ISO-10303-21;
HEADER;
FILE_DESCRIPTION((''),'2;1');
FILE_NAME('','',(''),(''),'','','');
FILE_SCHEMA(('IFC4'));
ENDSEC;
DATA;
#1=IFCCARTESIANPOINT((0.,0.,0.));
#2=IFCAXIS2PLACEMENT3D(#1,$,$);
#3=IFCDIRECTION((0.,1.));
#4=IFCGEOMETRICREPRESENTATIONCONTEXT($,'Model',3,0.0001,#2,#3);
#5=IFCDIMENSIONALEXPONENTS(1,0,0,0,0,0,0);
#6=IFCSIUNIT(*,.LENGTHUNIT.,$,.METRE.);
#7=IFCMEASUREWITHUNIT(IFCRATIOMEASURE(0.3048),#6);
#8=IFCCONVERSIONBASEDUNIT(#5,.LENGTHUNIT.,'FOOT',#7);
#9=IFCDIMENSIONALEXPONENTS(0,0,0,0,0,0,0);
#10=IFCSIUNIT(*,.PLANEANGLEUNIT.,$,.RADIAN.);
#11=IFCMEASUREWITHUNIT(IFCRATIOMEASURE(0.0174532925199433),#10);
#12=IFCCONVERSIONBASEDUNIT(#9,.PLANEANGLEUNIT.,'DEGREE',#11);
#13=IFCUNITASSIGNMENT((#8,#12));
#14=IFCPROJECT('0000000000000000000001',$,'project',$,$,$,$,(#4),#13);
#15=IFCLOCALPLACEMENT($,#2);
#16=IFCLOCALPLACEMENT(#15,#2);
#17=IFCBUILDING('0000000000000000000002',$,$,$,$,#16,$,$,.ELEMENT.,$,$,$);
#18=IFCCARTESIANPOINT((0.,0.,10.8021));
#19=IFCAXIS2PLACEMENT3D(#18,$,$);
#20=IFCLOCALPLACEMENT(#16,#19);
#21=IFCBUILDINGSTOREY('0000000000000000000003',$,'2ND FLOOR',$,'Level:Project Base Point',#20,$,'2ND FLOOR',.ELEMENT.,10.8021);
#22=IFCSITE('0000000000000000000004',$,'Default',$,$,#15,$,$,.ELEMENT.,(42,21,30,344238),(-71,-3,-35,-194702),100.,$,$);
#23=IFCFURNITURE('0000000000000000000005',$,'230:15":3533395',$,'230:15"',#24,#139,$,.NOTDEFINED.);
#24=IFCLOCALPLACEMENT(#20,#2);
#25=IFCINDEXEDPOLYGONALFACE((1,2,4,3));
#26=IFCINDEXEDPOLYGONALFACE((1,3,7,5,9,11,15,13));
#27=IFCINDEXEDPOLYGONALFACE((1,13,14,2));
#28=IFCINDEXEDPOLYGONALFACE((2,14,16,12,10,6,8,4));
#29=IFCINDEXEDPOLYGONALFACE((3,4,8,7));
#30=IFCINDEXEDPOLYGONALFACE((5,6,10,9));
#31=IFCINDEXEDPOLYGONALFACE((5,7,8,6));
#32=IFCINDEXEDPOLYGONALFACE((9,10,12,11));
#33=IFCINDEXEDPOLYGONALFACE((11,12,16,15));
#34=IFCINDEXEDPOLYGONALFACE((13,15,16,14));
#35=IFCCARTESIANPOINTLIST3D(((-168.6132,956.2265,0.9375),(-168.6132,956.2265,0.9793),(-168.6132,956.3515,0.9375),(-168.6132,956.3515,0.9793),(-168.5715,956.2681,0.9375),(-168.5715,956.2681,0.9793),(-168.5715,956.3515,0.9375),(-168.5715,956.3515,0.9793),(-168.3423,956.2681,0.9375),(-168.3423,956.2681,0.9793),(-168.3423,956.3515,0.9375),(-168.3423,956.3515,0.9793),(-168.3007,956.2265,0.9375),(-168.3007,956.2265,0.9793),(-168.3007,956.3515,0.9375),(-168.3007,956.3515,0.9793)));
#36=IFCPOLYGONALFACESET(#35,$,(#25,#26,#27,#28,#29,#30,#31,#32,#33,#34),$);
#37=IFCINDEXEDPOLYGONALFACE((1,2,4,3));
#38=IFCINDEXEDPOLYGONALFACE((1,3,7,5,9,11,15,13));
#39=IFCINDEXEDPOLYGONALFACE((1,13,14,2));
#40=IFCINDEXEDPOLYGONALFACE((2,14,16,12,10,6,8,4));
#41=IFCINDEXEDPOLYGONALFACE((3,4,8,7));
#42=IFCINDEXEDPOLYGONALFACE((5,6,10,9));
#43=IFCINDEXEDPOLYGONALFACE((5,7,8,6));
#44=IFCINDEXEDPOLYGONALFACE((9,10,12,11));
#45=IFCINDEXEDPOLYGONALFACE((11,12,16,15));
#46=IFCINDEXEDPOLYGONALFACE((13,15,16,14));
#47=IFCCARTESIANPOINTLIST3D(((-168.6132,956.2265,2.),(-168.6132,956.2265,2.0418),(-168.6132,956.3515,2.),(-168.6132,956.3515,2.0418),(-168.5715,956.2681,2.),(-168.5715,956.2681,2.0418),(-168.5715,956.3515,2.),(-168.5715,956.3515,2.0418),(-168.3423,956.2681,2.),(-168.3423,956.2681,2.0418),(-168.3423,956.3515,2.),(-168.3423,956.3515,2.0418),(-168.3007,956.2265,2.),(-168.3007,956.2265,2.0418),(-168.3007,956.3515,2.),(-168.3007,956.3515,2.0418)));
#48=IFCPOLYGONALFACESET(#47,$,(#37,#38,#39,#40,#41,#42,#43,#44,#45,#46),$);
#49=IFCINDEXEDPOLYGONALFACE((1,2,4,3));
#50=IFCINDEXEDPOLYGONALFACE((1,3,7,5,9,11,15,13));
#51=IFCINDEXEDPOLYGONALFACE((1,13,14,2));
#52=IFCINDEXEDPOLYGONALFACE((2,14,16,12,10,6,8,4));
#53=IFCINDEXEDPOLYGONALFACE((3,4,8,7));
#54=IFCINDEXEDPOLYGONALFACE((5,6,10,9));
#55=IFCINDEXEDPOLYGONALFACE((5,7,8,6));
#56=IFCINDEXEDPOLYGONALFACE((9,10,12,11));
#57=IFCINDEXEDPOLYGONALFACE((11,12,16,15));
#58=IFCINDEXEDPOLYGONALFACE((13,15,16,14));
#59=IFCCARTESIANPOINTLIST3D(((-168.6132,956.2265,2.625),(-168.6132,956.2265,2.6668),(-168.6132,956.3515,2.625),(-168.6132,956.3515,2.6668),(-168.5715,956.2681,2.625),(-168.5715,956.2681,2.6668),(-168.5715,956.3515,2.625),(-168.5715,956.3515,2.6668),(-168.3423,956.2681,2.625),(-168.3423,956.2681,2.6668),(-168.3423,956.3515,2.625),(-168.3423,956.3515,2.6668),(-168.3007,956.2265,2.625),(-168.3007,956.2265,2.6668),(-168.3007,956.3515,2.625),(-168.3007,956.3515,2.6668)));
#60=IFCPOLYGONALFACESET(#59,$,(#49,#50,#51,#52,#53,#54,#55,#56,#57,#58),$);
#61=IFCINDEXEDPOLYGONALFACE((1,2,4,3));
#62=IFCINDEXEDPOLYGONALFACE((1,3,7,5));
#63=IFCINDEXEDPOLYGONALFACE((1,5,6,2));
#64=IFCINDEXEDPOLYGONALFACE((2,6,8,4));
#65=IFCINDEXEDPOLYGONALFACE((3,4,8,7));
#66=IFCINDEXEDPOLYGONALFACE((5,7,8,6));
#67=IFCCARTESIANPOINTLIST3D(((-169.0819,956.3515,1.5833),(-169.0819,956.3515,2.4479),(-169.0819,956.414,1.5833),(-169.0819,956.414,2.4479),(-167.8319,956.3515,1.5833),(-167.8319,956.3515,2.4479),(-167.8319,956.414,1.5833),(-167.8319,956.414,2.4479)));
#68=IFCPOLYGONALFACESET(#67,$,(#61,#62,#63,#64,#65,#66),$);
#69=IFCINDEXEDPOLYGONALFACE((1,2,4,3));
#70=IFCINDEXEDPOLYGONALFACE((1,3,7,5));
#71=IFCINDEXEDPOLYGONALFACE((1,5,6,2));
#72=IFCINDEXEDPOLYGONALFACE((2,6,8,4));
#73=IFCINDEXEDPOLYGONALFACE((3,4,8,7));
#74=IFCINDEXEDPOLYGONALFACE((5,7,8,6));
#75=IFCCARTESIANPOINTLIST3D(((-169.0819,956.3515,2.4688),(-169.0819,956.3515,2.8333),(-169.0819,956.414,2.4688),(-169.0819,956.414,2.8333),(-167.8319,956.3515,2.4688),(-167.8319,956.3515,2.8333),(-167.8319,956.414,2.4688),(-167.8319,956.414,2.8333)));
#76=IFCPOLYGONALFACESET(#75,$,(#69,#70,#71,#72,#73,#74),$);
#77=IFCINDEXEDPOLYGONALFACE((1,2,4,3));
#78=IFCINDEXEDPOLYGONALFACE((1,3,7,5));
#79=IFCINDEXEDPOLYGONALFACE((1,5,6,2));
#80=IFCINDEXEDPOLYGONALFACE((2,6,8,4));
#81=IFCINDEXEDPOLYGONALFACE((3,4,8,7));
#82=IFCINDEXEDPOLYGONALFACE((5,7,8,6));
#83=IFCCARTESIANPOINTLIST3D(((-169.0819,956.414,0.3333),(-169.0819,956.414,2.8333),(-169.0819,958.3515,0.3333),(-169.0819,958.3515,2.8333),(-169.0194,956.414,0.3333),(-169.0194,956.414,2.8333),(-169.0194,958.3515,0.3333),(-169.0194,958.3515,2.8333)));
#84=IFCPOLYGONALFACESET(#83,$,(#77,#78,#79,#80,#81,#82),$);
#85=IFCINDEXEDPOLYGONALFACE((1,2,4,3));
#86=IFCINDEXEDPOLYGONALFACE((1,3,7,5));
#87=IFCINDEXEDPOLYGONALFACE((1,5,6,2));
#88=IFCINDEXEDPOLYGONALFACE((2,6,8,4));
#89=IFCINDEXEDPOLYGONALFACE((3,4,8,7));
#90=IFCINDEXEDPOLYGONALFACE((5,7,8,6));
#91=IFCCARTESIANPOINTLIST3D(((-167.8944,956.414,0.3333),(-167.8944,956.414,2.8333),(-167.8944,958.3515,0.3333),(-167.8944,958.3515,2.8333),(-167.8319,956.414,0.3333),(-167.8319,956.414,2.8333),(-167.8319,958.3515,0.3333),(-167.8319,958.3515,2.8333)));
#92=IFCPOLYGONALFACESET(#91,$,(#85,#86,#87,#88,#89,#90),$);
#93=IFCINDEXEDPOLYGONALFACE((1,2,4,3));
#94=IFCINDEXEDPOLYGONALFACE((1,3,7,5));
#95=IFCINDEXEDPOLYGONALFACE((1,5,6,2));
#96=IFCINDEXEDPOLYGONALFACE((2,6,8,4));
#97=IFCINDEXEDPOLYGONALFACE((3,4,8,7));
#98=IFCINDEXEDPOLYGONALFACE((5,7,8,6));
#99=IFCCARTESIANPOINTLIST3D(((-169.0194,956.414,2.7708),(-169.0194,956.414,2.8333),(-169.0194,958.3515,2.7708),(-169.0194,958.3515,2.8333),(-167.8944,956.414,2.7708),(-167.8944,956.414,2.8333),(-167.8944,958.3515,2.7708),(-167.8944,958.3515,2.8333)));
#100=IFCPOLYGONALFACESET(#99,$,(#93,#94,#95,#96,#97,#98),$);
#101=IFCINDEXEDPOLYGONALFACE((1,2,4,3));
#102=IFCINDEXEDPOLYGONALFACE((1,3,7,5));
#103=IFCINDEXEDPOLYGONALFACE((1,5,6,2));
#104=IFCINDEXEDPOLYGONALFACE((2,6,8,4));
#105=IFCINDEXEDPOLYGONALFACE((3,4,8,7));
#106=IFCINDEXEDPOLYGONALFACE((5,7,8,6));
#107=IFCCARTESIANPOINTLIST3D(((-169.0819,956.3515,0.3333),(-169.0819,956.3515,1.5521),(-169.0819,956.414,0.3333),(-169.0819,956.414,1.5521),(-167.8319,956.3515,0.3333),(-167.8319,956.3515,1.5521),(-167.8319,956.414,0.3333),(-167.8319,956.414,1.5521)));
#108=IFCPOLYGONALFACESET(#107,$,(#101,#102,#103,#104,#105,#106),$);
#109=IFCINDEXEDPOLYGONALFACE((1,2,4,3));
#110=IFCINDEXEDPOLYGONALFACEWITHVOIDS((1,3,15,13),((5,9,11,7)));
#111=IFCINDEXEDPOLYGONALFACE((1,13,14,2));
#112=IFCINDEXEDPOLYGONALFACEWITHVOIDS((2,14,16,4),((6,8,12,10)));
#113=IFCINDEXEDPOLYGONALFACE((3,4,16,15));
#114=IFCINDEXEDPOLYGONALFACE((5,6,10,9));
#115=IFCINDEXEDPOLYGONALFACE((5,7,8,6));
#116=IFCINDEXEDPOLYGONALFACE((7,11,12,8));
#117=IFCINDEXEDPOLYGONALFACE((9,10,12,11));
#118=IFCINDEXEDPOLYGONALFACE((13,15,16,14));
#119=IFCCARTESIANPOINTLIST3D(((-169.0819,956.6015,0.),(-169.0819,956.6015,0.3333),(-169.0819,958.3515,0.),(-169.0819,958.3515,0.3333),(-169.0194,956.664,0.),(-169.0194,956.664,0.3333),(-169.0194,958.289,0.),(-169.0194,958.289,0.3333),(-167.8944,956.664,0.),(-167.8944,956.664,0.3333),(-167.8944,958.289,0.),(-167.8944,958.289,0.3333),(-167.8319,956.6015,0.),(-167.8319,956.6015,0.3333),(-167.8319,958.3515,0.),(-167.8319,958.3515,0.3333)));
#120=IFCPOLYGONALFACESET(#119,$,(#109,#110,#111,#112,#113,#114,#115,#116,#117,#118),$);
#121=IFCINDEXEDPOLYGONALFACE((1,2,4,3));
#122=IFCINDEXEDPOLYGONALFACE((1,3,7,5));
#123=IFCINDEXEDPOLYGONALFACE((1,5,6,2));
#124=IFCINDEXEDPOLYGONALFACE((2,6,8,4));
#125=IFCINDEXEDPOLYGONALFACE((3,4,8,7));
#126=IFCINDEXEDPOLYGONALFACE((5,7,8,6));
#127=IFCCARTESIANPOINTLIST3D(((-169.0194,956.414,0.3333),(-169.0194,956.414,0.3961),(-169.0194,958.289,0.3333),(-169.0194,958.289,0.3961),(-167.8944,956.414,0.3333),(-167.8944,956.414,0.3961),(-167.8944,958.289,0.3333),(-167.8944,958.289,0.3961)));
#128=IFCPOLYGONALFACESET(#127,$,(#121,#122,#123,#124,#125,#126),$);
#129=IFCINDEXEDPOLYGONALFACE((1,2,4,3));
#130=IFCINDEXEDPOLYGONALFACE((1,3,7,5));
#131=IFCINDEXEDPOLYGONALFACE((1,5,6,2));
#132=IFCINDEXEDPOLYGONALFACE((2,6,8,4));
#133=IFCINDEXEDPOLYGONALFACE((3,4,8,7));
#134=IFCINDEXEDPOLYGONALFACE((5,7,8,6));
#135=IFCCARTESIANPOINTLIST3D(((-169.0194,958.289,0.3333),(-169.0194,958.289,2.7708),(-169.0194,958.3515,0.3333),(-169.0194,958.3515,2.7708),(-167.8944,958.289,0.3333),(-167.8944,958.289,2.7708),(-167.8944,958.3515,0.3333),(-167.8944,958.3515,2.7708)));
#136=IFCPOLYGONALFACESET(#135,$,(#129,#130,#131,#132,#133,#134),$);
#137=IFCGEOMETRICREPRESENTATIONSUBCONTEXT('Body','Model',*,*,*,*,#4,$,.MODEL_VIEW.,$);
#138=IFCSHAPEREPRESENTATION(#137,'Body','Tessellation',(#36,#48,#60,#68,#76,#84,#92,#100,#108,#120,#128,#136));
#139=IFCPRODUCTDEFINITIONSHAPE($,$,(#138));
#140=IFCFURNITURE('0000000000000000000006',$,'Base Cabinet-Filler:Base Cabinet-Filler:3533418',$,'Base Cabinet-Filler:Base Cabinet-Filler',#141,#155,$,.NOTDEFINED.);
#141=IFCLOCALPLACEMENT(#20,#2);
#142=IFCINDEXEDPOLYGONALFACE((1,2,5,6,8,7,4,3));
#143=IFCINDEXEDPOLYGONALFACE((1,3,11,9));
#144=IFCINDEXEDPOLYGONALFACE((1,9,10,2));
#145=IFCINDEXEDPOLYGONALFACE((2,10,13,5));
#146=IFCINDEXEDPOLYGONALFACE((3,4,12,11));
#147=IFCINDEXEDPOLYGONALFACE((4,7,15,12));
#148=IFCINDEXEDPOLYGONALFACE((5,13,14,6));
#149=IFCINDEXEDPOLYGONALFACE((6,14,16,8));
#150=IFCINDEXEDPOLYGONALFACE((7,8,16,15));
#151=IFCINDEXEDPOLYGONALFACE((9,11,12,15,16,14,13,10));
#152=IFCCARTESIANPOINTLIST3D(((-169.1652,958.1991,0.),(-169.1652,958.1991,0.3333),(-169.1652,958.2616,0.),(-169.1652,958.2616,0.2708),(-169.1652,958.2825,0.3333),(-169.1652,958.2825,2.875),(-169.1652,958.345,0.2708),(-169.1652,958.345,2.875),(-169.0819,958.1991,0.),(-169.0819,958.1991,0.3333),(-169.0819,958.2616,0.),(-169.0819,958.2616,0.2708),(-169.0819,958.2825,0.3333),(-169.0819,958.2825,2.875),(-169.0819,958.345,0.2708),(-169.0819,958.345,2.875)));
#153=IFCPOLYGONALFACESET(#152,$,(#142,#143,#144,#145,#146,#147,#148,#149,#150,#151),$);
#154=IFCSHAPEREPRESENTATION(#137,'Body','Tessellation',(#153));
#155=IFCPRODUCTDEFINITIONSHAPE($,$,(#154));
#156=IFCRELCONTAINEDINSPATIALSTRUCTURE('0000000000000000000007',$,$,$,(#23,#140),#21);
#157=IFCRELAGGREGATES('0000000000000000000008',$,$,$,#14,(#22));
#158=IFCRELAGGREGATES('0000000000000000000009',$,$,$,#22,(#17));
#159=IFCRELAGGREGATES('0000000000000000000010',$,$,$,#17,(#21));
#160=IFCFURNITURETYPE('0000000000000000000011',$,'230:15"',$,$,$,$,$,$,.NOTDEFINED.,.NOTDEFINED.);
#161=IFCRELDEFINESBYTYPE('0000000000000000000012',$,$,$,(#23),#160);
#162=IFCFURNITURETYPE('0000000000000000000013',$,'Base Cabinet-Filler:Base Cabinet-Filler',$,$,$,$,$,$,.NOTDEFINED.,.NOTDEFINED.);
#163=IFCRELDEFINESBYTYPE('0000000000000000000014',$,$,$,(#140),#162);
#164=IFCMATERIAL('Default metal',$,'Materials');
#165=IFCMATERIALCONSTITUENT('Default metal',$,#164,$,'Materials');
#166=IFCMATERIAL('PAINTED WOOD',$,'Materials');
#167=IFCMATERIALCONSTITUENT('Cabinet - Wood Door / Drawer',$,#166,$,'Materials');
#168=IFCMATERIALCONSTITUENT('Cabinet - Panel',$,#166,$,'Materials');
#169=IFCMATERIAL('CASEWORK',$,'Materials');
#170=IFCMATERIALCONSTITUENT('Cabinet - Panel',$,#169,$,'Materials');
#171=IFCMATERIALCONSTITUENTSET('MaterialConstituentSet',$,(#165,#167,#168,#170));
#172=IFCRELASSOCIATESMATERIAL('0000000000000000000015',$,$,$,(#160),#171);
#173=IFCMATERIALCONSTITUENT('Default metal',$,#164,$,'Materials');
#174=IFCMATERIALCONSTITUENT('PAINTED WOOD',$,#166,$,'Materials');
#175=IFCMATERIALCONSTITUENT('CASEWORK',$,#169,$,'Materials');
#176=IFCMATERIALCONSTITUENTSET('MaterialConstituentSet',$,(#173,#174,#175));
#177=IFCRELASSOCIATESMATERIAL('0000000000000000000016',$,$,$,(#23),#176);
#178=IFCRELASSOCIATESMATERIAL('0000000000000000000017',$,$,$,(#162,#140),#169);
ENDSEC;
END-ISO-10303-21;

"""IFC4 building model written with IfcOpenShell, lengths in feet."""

from ifc_helpers import new_model, entity, si_unit, converted_unit, direction, frame, frame_2d, origin, origin_2d_with_axis, place, context, subcontext, project, spatial, polyline, rectangle, outline, extrude, source, transform, mapped, material, constituent, constituent_set, type_object, type_shapes, element, save


model = new_model("IFC4")

# Units and contexts
model_context = context("Model", 3, precision=0.0001, world=origin(), true_north=direction((0.0, 1.0)))
body_context = subcontext(model_context, "Body", "Model", "MODEL_VIEW")
ifc_project = project(units=[converted_unit("LENGTHUNIT", "FOOT", entity("IfcRatioMeasure", 0.3048), si_unit("LENGTHUNIT", "METRE"), dimensions=[1, 0, 0, 0, 0, 0, 0]), converted_unit("PLANEANGLEUNIT", "DEGREE", entity("IfcRatioMeasure", 0.0174532925199433), si_unit("PLANEANGLEUNIT", "RADIAN"), dimensions=[0, 0, 0, 0, 0, 0, 0])], contexts=[model_context])

# Site, building, storey
site_placement = place(None, origin())
site = spatial("IfcSite", under=ifc_project, at=site_placement, Name="Default", CompositionType="ELEMENT", RefLatitude=(42, 21, 30, 344238), RefLongitude=(-71, -3, -35, -194702), RefElevation=100.0)
building_placement = place(site_placement, origin())
building = spatial("IfcBuilding", under=site, at=building_placement, CompositionType="ELEMENT")
storey_placement = place(building_placement, frame((0.0, 0.0, 10.8021)))
storey = spatial("IfcBuildingStorey", under=building, at=storey_placement, Name="2ND FLOOR", ObjectType="Level:Project Base Point", LongName="2ND FLOOR", CompositionType="ELEMENT", Elevation=10.8021)

# Shared definitions
ifc_material_1 = material(Name="Default metal", Category="Materials")
ifc_material_2 = material(Name="PAINTED WOOD", Category="Materials")
ifc_material_3 = material(Name="CASEWORK", Category="Materials")

# Furniture
ifc_constituent_1 = constituent(ifc_material_1, Name="Default metal", Category="Materials")
ifc_constituent_2 = constituent(ifc_material_2, Name="PAINTED WOOD", Category="Materials")
ifc_constituent_3 = constituent(ifc_material_3, Name="CASEWORK", Category="Materials")
ifc_constituent_set_1 = constituent_set(constituents=[ifc_constituent_1, ifc_constituent_2, ifc_constituent_3], Name="MaterialConstituentSet")
ifc_constituent_4 = constituent(ifc_material_1, Name="Default metal", Category="Materials")
ifc_constituent_5 = constituent(ifc_material_2, Name="Cabinet - Wood Door / Drawer", Category="Materials")
ifc_constituent_6 = constituent(ifc_material_2, Name="Cabinet - Panel", Category="Materials")
ifc_constituent_7 = constituent(ifc_material_3, Name="Cabinet - Panel", Category="Materials")
ifc_constituent_set_2 = constituent_set(constituents=[ifc_constituent_4, ifc_constituent_5, ifc_constituent_6, ifc_constituent_7], Name="MaterialConstituentSet")
furniture_type_1 = type_object("IfcFurnitureType", Name="230:15\"", AssemblyPlace="NOTDEFINED", PredefinedType="NOTDEFINED", material=ifc_constituent_set_2)
shared_shape_1 = source(origin(), body_context, "Body", "SweptSolid", [
    extrude(outline(polyline([(-0.0521, -0.1562), (0.0729, -0.1562), (0.0729, 0.1562), (-0.0521, 0.1562), (-0.0521, 0.1146), (0.0313, 0.1146), (0.0313, -0.1146), (-0.0521, -0.1146), (-0.0521, -0.1562)])), frame((0.0615, -2.0521, 0.9375), z_axis=(0.0, 0.0, 1.0), x_axis=(0.0, -1.0, 0.0)), (0.0, 0.0, 1.0), 0.0418),
    extrude(outline(polyline([(-0.0521, -0.1562), (0.0729, -0.1562), (0.0729, 0.1562), (-0.0521, 0.1562), (-0.0521, 0.1146), (0.0313, 0.1146), (0.0313, -0.1146), (-0.0521, -0.1146), (-0.0521, -0.1562)])), frame((0.0615, -2.0521, 2.0), z_axis=(0.0, 0.0, 1.0), x_axis=(0.0, -1.0, 0.0)), (0.0, 0.0, 1.0), 0.0418),
    extrude(outline(polyline([(-0.0521, -0.1562), (0.0729, -0.1562), (0.0729, 0.1562), (-0.0521, 0.1562), (-0.0521, 0.1146), (0.0313, 0.1146), (0.0313, -0.1146), (-0.0521, -0.1146), (-0.0521, -0.1562)])), frame((0.0615, -2.0521, 2.625), z_axis=(0.0, 0.0, 1.0), x_axis=(0.0, -1.0, 0.0)), (0.0, 0.0, 1.0), 0.0418),
    extrude(rectangle(XDim=0.0625, YDim=1.25, at=frame_2d((0.0, 0.0), x_axis=(1.0, 0.0))), frame((0.0615, -1.9688, 1.5833), z_axis=(0.0, 0.0, 1.0), x_axis=(0.0, 1.0, 0.0)), (0.0, 0.0, 1.0), 0.8646),
    extrude(rectangle(XDim=0.0625, YDim=1.25, at=frame_2d((0.0, 0.0), x_axis=(1.0, 0.0))), frame((0.0615, -1.9688, 2.4688), z_axis=(0.0, 0.0, 1.0), x_axis=(0.0, 1.0, 0.0)), (0.0, 0.0, 1.0), 0.3646),
    extrude(rectangle(XDim=0.0625, YDim=1.9375, at=frame_2d((0.0, 0.0), x_axis=(1.0, 0.0))), frame((-0.5323, -0.9687, 0.3333)), (0.0, 0.0, 1.0), 2.5),
    extrude(rectangle(XDim=0.0625, YDim=1.9375, at=frame_2d((0.0, 0.0), x_axis=(1.0, 0.0))), frame((0.6552, -0.9687, 0.3333)), (0.0, 0.0, 1.0), 2.5),
    extrude(rectangle(XDim=1.125, YDim=1.9375, at=origin_2d_with_axis()), frame((0.0615, -0.9687, 2.7708), z_axis=(0.0, 0.0, 1.0), x_axis=(-1.0, 0.0, 0.0)), (0.0, 0.0, 1.0), 0.0625),
    extrude(rectangle(XDim=0.0625, YDim=1.25, at=frame_2d((0.0, 0.0), x_axis=(1.0, 0.0))), frame((0.0615, -1.9688, 0.3333), z_axis=(0.0, 0.0, 1.0), x_axis=(0.0, 1.0, 0.0)), (0.0, 0.0, 1.0), 1.2187),
    extrude(outline(polyline([(-0.625, -0.875), (0.625, -0.875), (0.625, 0.875), (-0.625, 0.875), (-0.625, -0.875)]), holes=[polyline([(-0.5625, -0.8125), (-0.5625, 0.8125), (0.5625, 0.8125), (0.5625, -0.8125), (-0.5625, -0.8125)])]), frame((0.0615, -0.875, 0.0)), (0.0, 0.0, 1.0), 0.3333),
    extrude(rectangle(XDim=1.125, YDim=1.875, at=frame_2d((0.0, 0.0), x_axis=(1.0, 0.0))), frame((0.0615, -1.0, 0.3333), z_axis=(0.0, 0.0, 1.0), x_axis=(-1.0, 0.0, 0.0)), (0.0, 0.0, 1.0), 0.0627),
    extrude(rectangle(XDim=0.0625, YDim=1.125, at=origin_2d_with_axis()), frame((0.0615, -0.0312, 0.3333), z_axis=(0.0, 0.0, 1.0), x_axis=(0.0, 1.0, 0.0)), (0.0, 0.0, 1.0), 2.4375),
])
type_shapes(furniture_type_1, [shared_shape_1])
furniture_1_placement = place(storey_placement, frame((-168.5184, 958.3515, 0.0)))
element("IfcFurniture", 1, at=furniture_1_placement, inside=storey, type_object=furniture_type_1, material=ifc_constituent_set_1, Name="230:15\":3533395", ObjectType="230:15\"", PredefinedType="NOTDEFINED", context=body_context, shape_type="MappedRepresentation", body=[
    mapped(shared_shape_1, transform((0.0, 0.0, 0.0), scale=1.0)),
])
furniture_type_2 = type_object("IfcFurnitureType", Name="Base Cabinet-Filler:Base Cabinet-Filler", AssemblyPlace="NOTDEFINED", PredefinedType="NOTDEFINED", material=ifc_material_3)
shared_shape_2 = source(origin(), body_context, "Body", "SweptSolid", [
    extrude(outline(polyline([(-0.599, -0.0729), (2.0052, -0.0729), (2.0052, -0.0104), (-0.5365, -0.0104), (-0.5365, 0.0729), (-0.8698, 0.0729), (-0.8698, 0.0104), (-0.599, 0.0104), (-0.599, -0.0729)])), frame((0.0, 0.0729, 0.8698), z_axis=(1.0, 0.0, 0.0), x_axis=(0.0, 0.0, 1.0)), (0.0, 0.0, 1.0), 0.0833),
])
type_shapes(furniture_type_2, [shared_shape_2])
furniture_2_placement = place(storey_placement, frame((-169.1652, 958.1991, 0.0)))
element("IfcFurniture", 2, at=furniture_2_placement, inside=storey, type_object=furniture_type_2, material=ifc_material_3, Name="Base Cabinet-Filler:Base Cabinet-Filler:3533418", ObjectType="Base Cabinet-Filler:Base Cabinet-Filler", PredefinedType="NOTDEFINED", context=body_context, shape_type="MappedRepresentation", body=[
    mapped(shared_shape_2, transform((0.0, 0.0, 0.0), scale=1.0)),
])

save(model, "model.ifc")
